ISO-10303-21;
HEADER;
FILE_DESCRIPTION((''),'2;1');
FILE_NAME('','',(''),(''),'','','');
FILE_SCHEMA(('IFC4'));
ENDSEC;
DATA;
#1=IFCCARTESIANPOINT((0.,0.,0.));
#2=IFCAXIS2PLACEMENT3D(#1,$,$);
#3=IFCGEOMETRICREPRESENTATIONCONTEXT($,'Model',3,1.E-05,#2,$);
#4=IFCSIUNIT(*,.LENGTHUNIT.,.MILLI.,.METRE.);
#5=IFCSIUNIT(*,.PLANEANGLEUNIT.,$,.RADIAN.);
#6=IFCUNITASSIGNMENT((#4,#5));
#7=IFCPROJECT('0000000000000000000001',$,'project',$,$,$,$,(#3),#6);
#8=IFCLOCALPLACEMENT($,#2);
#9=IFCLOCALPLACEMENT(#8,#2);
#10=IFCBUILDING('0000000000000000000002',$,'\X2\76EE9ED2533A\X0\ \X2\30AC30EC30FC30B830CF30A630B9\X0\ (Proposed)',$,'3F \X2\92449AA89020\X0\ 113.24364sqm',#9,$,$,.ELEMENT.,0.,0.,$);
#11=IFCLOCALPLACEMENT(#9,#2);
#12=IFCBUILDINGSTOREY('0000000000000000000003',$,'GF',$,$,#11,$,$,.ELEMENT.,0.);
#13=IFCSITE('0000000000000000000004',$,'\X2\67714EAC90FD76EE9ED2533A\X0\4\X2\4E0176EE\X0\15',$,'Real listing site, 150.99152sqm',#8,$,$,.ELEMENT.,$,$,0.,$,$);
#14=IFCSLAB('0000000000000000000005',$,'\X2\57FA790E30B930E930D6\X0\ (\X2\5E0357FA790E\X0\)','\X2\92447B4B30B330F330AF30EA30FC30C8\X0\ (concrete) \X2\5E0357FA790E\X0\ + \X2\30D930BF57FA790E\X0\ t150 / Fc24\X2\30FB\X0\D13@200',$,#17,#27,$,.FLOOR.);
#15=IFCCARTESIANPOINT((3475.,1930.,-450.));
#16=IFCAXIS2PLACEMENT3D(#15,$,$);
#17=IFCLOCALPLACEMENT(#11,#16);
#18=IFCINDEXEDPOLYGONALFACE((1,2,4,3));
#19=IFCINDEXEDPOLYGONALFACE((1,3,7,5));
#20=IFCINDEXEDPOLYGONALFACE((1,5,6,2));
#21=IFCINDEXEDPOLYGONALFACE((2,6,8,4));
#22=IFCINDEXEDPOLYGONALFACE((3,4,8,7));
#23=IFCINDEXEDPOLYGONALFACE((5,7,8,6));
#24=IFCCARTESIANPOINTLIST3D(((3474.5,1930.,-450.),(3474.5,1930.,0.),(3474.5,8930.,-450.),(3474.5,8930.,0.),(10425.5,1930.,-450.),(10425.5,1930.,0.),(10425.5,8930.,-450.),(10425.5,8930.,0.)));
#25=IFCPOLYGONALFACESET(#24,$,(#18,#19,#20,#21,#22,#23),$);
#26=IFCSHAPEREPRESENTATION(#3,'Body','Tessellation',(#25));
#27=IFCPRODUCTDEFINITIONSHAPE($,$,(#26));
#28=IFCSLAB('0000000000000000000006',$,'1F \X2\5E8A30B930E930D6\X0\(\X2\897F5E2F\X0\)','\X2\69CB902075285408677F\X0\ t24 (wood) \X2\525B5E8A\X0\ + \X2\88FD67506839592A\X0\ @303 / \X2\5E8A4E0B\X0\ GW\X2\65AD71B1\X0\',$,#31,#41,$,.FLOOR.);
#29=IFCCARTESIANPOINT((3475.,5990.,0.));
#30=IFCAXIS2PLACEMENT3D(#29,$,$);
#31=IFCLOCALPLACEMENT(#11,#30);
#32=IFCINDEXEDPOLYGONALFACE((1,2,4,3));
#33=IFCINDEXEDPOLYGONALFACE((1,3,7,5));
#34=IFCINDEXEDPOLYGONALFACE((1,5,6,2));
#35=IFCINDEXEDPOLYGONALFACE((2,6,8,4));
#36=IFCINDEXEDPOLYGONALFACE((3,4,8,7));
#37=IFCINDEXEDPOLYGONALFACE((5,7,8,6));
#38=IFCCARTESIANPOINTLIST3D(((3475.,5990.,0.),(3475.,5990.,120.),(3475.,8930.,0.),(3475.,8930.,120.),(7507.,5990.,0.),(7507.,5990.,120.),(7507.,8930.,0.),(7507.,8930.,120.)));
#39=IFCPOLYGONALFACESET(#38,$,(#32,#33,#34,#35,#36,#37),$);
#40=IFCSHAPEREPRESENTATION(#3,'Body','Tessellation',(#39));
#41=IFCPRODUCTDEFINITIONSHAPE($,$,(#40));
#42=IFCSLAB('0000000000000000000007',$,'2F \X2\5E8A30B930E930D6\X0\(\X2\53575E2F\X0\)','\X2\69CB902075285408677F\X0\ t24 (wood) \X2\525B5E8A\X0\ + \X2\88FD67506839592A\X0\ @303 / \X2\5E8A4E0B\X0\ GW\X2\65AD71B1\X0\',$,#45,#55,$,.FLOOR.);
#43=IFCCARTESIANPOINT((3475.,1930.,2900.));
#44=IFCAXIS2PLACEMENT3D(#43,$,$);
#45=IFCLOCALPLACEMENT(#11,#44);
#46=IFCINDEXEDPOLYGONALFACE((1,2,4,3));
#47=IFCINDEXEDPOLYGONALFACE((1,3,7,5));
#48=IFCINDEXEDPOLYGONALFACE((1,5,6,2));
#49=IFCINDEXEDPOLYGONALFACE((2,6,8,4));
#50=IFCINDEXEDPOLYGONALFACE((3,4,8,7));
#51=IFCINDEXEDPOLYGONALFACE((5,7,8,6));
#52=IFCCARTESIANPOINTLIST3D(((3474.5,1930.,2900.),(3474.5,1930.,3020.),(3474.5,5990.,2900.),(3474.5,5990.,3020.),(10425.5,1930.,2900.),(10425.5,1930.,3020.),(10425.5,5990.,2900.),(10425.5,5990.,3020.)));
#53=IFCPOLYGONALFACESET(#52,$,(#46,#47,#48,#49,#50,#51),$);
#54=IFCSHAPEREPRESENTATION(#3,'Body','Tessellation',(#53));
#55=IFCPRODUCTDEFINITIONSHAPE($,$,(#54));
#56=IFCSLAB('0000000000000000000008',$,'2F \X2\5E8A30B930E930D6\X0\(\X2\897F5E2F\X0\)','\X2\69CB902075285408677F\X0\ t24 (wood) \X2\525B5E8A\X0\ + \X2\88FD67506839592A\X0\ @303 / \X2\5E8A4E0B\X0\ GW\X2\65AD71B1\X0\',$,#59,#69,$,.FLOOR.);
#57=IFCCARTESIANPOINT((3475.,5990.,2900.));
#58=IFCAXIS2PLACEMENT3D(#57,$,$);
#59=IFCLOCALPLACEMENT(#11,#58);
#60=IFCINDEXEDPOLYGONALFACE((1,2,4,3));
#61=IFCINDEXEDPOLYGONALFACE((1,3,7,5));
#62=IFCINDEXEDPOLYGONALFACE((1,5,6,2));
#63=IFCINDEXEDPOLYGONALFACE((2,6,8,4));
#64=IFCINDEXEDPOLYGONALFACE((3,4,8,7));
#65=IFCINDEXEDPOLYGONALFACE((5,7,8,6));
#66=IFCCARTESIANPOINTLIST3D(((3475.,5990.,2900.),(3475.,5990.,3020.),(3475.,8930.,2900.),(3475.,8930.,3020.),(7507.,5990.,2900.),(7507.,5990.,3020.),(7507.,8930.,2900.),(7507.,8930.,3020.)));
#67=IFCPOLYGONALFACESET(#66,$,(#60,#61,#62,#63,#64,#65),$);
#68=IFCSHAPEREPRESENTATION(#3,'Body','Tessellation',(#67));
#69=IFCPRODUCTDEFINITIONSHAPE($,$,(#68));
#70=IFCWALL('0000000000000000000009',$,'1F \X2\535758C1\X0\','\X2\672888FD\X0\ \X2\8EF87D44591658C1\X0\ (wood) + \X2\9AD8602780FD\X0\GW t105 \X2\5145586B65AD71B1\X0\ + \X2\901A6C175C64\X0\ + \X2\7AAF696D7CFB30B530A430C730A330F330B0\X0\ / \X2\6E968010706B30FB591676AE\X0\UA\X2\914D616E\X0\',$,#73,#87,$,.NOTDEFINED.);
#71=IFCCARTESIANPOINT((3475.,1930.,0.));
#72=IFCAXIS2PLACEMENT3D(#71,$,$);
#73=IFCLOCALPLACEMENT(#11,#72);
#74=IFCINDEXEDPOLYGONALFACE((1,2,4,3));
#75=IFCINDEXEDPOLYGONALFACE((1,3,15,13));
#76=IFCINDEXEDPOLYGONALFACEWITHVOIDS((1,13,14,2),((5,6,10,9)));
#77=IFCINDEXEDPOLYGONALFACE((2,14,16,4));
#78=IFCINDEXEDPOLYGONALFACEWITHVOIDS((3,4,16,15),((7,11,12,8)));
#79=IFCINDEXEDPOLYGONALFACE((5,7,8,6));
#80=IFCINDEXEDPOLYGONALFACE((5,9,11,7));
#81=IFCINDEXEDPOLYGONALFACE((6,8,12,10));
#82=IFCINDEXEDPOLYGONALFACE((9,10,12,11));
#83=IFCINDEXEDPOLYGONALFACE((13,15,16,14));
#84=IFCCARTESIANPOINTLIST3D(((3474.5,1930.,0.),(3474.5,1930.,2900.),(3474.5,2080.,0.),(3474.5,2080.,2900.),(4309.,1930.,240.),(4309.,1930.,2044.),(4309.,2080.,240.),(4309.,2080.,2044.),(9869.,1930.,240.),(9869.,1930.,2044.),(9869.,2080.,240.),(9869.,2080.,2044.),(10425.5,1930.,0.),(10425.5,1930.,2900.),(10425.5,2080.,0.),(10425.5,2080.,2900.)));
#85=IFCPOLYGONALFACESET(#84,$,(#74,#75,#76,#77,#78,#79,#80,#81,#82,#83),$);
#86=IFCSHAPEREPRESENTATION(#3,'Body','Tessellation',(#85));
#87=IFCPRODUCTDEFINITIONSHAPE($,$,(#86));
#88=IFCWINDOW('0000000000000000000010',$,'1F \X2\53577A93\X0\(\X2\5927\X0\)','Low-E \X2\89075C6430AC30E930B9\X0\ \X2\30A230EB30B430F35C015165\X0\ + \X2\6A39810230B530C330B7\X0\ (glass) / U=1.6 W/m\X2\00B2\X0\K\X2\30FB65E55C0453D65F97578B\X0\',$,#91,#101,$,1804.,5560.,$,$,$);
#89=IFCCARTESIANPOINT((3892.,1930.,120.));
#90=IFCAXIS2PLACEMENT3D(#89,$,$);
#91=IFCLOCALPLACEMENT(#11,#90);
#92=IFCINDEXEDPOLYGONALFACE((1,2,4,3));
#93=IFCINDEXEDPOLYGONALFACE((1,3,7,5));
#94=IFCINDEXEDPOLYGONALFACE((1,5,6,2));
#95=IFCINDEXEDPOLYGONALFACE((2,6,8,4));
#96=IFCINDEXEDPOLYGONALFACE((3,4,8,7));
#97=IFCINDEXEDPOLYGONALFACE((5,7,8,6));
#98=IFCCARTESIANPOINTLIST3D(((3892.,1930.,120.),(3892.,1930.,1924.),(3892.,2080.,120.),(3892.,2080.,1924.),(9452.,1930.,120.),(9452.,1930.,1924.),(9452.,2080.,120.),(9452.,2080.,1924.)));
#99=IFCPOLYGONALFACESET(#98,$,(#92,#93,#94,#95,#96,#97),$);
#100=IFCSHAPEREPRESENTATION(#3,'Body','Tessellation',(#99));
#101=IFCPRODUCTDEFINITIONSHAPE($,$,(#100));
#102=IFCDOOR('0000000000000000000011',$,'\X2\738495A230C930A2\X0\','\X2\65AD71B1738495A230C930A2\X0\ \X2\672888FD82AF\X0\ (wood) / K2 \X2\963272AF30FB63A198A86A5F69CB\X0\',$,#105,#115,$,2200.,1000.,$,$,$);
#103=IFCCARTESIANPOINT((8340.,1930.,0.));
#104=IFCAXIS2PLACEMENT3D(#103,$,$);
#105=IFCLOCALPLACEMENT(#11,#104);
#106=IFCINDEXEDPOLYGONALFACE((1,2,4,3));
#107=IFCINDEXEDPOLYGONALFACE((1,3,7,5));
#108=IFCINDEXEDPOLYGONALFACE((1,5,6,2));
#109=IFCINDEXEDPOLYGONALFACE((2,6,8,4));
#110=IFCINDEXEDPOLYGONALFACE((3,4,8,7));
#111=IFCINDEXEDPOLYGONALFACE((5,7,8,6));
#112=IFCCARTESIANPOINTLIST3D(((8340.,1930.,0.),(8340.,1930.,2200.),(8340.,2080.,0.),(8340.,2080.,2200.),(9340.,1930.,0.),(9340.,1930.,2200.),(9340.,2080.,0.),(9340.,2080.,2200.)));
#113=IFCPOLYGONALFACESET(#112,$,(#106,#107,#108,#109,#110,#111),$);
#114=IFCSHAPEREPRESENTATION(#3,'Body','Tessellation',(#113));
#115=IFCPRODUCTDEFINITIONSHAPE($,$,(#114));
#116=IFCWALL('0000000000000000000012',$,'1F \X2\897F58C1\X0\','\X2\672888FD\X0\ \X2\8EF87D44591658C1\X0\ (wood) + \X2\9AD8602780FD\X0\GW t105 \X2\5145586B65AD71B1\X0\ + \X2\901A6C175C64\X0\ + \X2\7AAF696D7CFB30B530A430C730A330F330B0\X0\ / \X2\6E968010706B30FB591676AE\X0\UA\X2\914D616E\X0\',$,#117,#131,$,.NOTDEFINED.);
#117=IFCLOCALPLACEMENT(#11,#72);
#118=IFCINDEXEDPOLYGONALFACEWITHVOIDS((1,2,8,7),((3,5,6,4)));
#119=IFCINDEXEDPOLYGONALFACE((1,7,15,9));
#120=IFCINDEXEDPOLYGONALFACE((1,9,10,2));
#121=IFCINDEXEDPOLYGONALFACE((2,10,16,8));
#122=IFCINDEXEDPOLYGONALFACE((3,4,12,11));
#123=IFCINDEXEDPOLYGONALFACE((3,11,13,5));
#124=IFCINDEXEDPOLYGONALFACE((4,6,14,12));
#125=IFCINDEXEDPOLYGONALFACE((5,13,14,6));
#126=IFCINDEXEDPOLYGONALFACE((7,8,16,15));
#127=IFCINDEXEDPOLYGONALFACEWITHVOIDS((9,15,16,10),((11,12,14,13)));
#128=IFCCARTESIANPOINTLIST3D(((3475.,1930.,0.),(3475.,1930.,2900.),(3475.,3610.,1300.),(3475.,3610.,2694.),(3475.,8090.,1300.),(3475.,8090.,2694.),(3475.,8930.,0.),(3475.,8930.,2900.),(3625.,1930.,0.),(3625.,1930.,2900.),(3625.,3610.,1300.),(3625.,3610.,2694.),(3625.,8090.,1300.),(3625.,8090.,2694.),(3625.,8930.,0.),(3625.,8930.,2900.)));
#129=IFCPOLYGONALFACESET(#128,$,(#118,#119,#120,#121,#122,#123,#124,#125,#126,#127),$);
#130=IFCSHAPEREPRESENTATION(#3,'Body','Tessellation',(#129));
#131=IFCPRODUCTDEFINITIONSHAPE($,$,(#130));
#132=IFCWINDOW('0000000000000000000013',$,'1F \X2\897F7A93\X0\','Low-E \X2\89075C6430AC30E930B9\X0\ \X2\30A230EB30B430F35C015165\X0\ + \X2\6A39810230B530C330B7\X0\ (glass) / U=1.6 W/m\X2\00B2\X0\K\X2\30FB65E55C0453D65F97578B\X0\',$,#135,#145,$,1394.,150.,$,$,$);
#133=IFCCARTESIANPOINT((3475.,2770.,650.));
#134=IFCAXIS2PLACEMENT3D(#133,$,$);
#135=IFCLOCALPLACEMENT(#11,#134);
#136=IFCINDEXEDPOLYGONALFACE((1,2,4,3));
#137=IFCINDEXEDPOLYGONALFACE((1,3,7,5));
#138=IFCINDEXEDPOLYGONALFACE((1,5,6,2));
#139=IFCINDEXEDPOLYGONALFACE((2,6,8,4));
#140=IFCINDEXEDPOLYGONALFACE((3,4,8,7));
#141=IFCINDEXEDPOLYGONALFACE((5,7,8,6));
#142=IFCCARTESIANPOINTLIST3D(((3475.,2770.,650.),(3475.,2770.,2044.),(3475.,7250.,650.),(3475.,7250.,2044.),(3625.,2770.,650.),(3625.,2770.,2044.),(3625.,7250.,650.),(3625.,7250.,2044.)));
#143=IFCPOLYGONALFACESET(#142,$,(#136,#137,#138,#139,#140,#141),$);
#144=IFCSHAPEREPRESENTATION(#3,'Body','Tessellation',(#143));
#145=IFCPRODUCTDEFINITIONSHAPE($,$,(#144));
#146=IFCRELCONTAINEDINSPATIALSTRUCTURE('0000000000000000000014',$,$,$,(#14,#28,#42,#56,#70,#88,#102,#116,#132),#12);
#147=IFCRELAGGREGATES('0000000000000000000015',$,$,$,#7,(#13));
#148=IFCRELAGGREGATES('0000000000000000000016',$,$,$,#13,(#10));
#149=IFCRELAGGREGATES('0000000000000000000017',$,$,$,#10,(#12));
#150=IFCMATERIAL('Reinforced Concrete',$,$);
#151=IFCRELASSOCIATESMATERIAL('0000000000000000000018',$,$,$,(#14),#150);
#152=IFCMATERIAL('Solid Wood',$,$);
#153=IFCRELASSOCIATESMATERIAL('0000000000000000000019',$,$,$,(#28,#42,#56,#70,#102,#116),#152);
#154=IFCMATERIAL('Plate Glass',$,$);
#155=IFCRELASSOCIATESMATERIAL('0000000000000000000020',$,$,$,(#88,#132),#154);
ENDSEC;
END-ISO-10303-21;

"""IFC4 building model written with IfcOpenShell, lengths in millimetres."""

from ifc_helpers import new_model, si_unit, frame, frame_2d, origin, place, context, project, spatial, rectangle, extrude, material, element, fill, save


model = new_model("IFC4")

# Units and contexts
model_context = context("Model", 3, precision=1e-05, world=origin())
ifc_project = project(units=[si_unit("LENGTHUNIT", "METRE", prefix="MILLI"), si_unit("PLANEANGLEUNIT", "RADIAN")], contexts=[model_context])

# Site, building, storey
site_placement = place(None, origin())
site = spatial("IfcSite", under=ifc_project, at=site_placement, Name="東京都目黒区4丁目15", ObjectType="Real listing site, 150.99152sqm", CompositionType="ELEMENT", RefElevation=0.0)
building_placement = place(site_placement, origin())
building = spatial("IfcBuilding", under=site, at=building_placement, Name="目黒区 ガレージハウス (Proposed)", ObjectType="3F 鉄骨造 113.24364sqm", CompositionType="ELEMENT", ElevationOfRefHeight=0.0, ElevationOfTerrain=0.0)
storey_placement = place(building_placement, origin())
storey = spatial("IfcBuildingStorey", under=building, at=storey_placement, Name="GF", CompositionType="ELEMENT", Elevation=0.0)

# Slabs
ifc_material_1 = material(Name="Reinforced Concrete")
slab_1_placement = place(storey_placement, frame((3475.0, 1930.0, -450.0)))
element("IfcSlab", 1, at=slab_1_placement, inside=storey, material=ifc_material_1, Name="基礎スラブ (布基礎)", Description="鉄筋コンクリート (concrete) 布基礎 + ベタ基礎 t150 / Fc24・D13@200", PredefinedType="FLOOR", context=model_context, shape_type="SweptSolid", body=[
    extrude(rectangle(XDim=6951.0, YDim=7000.0, at=frame_2d((3475.0, 3500.0))), frame((3475.0, 1930.0, -450.0)), (0.0, 0.0, 1.0), 450.0),
])
ifc_material_2 = material(Name="Solid Wood")
slab_2_placement = place(storey_placement, frame((3475.0, 5990.0, 0.0)))
element("IfcSlab", 2, at=slab_2_placement, inside=storey, material=ifc_material_2, Name="1F 床スラブ(西帯)", Description="構造用合板 t24 (wood) 剛床 + 製材根太 @303 / 床下 GW断熱", PredefinedType="FLOOR", context=model_context, shape_type="SweptSolid", body=[
    extrude(rectangle(XDim=4032.0, YDim=2940.0, at=frame_2d((2016.0, 1470.0))), frame((3475.0, 5990.0, 0.0)), (0.0, 0.0, 1.0), 120.0),
])
slab_3_placement = place(storey_placement, frame((3475.0, 1930.0, 2900.0)))
element("IfcSlab", 3, at=slab_3_placement, inside=storey, material=ifc_material_2, Name="2F 床スラブ(南帯)", Description="構造用合板 t24 (wood) 剛床 + 製材根太 @303 / 床下 GW断熱", PredefinedType="FLOOR", context=model_context, shape_type="SweptSolid", body=[
    extrude(rectangle(XDim=6951.0, YDim=4060.0, at=frame_2d((3475.0, 2030.0))), frame((3475.0, 1930.0, 2900.0)), (0.0, 0.0, 1.0), 120.0),
])
slab_4_placement = place(storey_placement, frame((3475.0, 5990.0, 2900.0)))
element("IfcSlab", 4, at=slab_4_placement, inside=storey, material=ifc_material_2, Name="2F 床スラブ(西帯)", Description="構造用合板 t24 (wood) 剛床 + 製材根太 @303 / 床下 GW断熱", PredefinedType="FLOOR", context=model_context, shape_type="SweptSolid", body=[
    extrude(rectangle(XDim=4032.0, YDim=2940.0, at=frame_2d((2016.0, 1470.0))), frame((3475.0, 5990.0, 2900.0)), (0.0, 0.0, 1.0), 120.0),
])

# Wall, openings, window, door
wall_1_placement = place(storey_placement, frame((3475.0, 1930.0, 0.0)))
wall_1 = element("IfcWall", 5, at=wall_1_placement, inside=storey, material=ifc_material_2, Name="1F 南壁", Description="木製 軸組外壁 (wood) + 高性能GW t105 充填断熱 + 通気層 + 窯業系サイディング / 準耐火・外皮UA配慮", PredefinedType="NOTDEFINED", context=model_context, shape_type="SweptSolid", body=[
    extrude(rectangle(XDim=6951.0, YDim=150.0, at=frame_2d((3475.0, 75.0))), frame((3475.0, 1930.0, 0.0)), (0.0, 0.0, 1.0), 2900.0),
])
opening_1_placement = place(storey_placement, frame((3892.0, 1930.0, 120.0)))
opening_1 = element("IfcOpeningElement", 6, at=opening_1_placement, cuts=wall_1, PredefinedType="NOTDEFINED", context=model_context, shape_type="SweptSolid", body=[
    extrude(rectangle(XDim=5560.0, YDim=150.0, at=frame_2d((2780.0, 75.0))), frame((3892.0, 1930.0, 120.0)), (0.0, 0.0, 1.0), 1804.0),
])
opening_2_placement = place(storey_placement, frame((8340.0, 1930.0, 0.0)))
opening_2 = element("IfcOpeningElement", 7, at=opening_2_placement, cuts=wall_1, PredefinedType="NOTDEFINED", context=model_context, shape_type="SweptSolid", body=[
    extrude(rectangle(XDim=1000.0, YDim=150.0, at=frame_2d((500.0, 75.0))), frame((8340.0, 1930.0, 0.0)), (0.0, 0.0, 1.0), 2200.0),
])
ifc_material_3 = material(Name="Plate Glass")
window_1_placement = place(storey_placement, frame((3892.0, 1930.0, 120.0)))
window_1 = element("IfcWindow", 8, at=window_1_placement, inside=storey, material=ifc_material_3, Name="1F 南窓(大)", Description="Low-E 複層ガラス アルゴン封入 + 樹脂サッシ (glass) / U=1.6 W/m²K・日射取得型", OverallHeight=1804.0, OverallWidth=5560.0, context=model_context, shape_type="SweptSolid", body=[
    extrude(rectangle(XDim=5560.0, YDim=150.0, at=frame_2d((2780.0, 75.0))), frame((3892.0, 1930.0, 120.0)), (0.0, 0.0, 1.0), 1804.0),
])
fill(opening_1, window_1)
door_placement = place(storey_placement, frame((8340.0, 1930.0, 0.0)))
door = element("IfcDoor", 9, at=door_placement, inside=storey, material=ifc_material_2, Name="玄関ドア", Description="断熱玄関ドア 木製芯 (wood) / K2 防犯・採風機構", OverallHeight=2200.0, OverallWidth=1000.0, context=model_context, shape_type="SweptSolid", body=[
    extrude(rectangle(XDim=1000.0, YDim=150.0, at=frame_2d((500.0, 75.0))), frame((8340.0, 1930.0, 0.0)), (0.0, 0.0, 1.0), 2200.0),
])
fill(opening_2, door)

# Wall, opening, window
wall_2_placement = place(storey_placement, frame((3475.0, 1930.0, 0.0)))
wall_2 = element("IfcWall", 10, at=wall_2_placement, inside=storey, material=ifc_material_2, Name="1F 西壁", Description="木製 軸組外壁 (wood) + 高性能GW t105 充填断熱 + 通気層 + 窯業系サイディング / 準耐火・外皮UA配慮", PredefinedType="NOTDEFINED", context=model_context, shape_type="SweptSolid", body=[
    extrude(rectangle(XDim=150.0, YDim=7000.0, at=frame_2d((75.0, 3500.0))), frame((3475.0, 1930.0, 0.0)), (0.0, 0.0, 1.0), 2900.0),
])
opening_3_placement = place(storey_placement, frame((3475.0, 2770.0, 650.0)))
opening_3 = element("IfcOpeningElement", 11, at=opening_3_placement, cuts=wall_2, PredefinedType="NOTDEFINED", context=model_context, shape_type="SweptSolid", body=[
    extrude(rectangle(XDim=150.0, YDim=4480.0, at=frame_2d((75.0, 2240.0))), frame((3475.0, 2770.0, 650.0)), (0.0, 0.0, 1.0), 1394.0),
])
window_2_placement = place(storey_placement, frame((3475.0, 2770.0, 650.0)))
window_2 = element("IfcWindow", 12, at=window_2_placement, inside=storey, material=ifc_material_3, Name="1F 西窓", Description="Low-E 複層ガラス アルゴン封入 + 樹脂サッシ (glass) / U=1.6 W/m²K・日射取得型", OverallHeight=1394.0, OverallWidth=150.0, context=model_context, shape_type="SweptSolid", body=[
    extrude(rectangle(XDim=150.0, YDim=4480.0, at=frame_2d((75.0, 2240.0))), frame((3475.0, 2770.0, 650.0)), (0.0, 0.0, 1.0), 1394.0),
])
fill(opening_3, window_2)

save(model, "model.ifc")
